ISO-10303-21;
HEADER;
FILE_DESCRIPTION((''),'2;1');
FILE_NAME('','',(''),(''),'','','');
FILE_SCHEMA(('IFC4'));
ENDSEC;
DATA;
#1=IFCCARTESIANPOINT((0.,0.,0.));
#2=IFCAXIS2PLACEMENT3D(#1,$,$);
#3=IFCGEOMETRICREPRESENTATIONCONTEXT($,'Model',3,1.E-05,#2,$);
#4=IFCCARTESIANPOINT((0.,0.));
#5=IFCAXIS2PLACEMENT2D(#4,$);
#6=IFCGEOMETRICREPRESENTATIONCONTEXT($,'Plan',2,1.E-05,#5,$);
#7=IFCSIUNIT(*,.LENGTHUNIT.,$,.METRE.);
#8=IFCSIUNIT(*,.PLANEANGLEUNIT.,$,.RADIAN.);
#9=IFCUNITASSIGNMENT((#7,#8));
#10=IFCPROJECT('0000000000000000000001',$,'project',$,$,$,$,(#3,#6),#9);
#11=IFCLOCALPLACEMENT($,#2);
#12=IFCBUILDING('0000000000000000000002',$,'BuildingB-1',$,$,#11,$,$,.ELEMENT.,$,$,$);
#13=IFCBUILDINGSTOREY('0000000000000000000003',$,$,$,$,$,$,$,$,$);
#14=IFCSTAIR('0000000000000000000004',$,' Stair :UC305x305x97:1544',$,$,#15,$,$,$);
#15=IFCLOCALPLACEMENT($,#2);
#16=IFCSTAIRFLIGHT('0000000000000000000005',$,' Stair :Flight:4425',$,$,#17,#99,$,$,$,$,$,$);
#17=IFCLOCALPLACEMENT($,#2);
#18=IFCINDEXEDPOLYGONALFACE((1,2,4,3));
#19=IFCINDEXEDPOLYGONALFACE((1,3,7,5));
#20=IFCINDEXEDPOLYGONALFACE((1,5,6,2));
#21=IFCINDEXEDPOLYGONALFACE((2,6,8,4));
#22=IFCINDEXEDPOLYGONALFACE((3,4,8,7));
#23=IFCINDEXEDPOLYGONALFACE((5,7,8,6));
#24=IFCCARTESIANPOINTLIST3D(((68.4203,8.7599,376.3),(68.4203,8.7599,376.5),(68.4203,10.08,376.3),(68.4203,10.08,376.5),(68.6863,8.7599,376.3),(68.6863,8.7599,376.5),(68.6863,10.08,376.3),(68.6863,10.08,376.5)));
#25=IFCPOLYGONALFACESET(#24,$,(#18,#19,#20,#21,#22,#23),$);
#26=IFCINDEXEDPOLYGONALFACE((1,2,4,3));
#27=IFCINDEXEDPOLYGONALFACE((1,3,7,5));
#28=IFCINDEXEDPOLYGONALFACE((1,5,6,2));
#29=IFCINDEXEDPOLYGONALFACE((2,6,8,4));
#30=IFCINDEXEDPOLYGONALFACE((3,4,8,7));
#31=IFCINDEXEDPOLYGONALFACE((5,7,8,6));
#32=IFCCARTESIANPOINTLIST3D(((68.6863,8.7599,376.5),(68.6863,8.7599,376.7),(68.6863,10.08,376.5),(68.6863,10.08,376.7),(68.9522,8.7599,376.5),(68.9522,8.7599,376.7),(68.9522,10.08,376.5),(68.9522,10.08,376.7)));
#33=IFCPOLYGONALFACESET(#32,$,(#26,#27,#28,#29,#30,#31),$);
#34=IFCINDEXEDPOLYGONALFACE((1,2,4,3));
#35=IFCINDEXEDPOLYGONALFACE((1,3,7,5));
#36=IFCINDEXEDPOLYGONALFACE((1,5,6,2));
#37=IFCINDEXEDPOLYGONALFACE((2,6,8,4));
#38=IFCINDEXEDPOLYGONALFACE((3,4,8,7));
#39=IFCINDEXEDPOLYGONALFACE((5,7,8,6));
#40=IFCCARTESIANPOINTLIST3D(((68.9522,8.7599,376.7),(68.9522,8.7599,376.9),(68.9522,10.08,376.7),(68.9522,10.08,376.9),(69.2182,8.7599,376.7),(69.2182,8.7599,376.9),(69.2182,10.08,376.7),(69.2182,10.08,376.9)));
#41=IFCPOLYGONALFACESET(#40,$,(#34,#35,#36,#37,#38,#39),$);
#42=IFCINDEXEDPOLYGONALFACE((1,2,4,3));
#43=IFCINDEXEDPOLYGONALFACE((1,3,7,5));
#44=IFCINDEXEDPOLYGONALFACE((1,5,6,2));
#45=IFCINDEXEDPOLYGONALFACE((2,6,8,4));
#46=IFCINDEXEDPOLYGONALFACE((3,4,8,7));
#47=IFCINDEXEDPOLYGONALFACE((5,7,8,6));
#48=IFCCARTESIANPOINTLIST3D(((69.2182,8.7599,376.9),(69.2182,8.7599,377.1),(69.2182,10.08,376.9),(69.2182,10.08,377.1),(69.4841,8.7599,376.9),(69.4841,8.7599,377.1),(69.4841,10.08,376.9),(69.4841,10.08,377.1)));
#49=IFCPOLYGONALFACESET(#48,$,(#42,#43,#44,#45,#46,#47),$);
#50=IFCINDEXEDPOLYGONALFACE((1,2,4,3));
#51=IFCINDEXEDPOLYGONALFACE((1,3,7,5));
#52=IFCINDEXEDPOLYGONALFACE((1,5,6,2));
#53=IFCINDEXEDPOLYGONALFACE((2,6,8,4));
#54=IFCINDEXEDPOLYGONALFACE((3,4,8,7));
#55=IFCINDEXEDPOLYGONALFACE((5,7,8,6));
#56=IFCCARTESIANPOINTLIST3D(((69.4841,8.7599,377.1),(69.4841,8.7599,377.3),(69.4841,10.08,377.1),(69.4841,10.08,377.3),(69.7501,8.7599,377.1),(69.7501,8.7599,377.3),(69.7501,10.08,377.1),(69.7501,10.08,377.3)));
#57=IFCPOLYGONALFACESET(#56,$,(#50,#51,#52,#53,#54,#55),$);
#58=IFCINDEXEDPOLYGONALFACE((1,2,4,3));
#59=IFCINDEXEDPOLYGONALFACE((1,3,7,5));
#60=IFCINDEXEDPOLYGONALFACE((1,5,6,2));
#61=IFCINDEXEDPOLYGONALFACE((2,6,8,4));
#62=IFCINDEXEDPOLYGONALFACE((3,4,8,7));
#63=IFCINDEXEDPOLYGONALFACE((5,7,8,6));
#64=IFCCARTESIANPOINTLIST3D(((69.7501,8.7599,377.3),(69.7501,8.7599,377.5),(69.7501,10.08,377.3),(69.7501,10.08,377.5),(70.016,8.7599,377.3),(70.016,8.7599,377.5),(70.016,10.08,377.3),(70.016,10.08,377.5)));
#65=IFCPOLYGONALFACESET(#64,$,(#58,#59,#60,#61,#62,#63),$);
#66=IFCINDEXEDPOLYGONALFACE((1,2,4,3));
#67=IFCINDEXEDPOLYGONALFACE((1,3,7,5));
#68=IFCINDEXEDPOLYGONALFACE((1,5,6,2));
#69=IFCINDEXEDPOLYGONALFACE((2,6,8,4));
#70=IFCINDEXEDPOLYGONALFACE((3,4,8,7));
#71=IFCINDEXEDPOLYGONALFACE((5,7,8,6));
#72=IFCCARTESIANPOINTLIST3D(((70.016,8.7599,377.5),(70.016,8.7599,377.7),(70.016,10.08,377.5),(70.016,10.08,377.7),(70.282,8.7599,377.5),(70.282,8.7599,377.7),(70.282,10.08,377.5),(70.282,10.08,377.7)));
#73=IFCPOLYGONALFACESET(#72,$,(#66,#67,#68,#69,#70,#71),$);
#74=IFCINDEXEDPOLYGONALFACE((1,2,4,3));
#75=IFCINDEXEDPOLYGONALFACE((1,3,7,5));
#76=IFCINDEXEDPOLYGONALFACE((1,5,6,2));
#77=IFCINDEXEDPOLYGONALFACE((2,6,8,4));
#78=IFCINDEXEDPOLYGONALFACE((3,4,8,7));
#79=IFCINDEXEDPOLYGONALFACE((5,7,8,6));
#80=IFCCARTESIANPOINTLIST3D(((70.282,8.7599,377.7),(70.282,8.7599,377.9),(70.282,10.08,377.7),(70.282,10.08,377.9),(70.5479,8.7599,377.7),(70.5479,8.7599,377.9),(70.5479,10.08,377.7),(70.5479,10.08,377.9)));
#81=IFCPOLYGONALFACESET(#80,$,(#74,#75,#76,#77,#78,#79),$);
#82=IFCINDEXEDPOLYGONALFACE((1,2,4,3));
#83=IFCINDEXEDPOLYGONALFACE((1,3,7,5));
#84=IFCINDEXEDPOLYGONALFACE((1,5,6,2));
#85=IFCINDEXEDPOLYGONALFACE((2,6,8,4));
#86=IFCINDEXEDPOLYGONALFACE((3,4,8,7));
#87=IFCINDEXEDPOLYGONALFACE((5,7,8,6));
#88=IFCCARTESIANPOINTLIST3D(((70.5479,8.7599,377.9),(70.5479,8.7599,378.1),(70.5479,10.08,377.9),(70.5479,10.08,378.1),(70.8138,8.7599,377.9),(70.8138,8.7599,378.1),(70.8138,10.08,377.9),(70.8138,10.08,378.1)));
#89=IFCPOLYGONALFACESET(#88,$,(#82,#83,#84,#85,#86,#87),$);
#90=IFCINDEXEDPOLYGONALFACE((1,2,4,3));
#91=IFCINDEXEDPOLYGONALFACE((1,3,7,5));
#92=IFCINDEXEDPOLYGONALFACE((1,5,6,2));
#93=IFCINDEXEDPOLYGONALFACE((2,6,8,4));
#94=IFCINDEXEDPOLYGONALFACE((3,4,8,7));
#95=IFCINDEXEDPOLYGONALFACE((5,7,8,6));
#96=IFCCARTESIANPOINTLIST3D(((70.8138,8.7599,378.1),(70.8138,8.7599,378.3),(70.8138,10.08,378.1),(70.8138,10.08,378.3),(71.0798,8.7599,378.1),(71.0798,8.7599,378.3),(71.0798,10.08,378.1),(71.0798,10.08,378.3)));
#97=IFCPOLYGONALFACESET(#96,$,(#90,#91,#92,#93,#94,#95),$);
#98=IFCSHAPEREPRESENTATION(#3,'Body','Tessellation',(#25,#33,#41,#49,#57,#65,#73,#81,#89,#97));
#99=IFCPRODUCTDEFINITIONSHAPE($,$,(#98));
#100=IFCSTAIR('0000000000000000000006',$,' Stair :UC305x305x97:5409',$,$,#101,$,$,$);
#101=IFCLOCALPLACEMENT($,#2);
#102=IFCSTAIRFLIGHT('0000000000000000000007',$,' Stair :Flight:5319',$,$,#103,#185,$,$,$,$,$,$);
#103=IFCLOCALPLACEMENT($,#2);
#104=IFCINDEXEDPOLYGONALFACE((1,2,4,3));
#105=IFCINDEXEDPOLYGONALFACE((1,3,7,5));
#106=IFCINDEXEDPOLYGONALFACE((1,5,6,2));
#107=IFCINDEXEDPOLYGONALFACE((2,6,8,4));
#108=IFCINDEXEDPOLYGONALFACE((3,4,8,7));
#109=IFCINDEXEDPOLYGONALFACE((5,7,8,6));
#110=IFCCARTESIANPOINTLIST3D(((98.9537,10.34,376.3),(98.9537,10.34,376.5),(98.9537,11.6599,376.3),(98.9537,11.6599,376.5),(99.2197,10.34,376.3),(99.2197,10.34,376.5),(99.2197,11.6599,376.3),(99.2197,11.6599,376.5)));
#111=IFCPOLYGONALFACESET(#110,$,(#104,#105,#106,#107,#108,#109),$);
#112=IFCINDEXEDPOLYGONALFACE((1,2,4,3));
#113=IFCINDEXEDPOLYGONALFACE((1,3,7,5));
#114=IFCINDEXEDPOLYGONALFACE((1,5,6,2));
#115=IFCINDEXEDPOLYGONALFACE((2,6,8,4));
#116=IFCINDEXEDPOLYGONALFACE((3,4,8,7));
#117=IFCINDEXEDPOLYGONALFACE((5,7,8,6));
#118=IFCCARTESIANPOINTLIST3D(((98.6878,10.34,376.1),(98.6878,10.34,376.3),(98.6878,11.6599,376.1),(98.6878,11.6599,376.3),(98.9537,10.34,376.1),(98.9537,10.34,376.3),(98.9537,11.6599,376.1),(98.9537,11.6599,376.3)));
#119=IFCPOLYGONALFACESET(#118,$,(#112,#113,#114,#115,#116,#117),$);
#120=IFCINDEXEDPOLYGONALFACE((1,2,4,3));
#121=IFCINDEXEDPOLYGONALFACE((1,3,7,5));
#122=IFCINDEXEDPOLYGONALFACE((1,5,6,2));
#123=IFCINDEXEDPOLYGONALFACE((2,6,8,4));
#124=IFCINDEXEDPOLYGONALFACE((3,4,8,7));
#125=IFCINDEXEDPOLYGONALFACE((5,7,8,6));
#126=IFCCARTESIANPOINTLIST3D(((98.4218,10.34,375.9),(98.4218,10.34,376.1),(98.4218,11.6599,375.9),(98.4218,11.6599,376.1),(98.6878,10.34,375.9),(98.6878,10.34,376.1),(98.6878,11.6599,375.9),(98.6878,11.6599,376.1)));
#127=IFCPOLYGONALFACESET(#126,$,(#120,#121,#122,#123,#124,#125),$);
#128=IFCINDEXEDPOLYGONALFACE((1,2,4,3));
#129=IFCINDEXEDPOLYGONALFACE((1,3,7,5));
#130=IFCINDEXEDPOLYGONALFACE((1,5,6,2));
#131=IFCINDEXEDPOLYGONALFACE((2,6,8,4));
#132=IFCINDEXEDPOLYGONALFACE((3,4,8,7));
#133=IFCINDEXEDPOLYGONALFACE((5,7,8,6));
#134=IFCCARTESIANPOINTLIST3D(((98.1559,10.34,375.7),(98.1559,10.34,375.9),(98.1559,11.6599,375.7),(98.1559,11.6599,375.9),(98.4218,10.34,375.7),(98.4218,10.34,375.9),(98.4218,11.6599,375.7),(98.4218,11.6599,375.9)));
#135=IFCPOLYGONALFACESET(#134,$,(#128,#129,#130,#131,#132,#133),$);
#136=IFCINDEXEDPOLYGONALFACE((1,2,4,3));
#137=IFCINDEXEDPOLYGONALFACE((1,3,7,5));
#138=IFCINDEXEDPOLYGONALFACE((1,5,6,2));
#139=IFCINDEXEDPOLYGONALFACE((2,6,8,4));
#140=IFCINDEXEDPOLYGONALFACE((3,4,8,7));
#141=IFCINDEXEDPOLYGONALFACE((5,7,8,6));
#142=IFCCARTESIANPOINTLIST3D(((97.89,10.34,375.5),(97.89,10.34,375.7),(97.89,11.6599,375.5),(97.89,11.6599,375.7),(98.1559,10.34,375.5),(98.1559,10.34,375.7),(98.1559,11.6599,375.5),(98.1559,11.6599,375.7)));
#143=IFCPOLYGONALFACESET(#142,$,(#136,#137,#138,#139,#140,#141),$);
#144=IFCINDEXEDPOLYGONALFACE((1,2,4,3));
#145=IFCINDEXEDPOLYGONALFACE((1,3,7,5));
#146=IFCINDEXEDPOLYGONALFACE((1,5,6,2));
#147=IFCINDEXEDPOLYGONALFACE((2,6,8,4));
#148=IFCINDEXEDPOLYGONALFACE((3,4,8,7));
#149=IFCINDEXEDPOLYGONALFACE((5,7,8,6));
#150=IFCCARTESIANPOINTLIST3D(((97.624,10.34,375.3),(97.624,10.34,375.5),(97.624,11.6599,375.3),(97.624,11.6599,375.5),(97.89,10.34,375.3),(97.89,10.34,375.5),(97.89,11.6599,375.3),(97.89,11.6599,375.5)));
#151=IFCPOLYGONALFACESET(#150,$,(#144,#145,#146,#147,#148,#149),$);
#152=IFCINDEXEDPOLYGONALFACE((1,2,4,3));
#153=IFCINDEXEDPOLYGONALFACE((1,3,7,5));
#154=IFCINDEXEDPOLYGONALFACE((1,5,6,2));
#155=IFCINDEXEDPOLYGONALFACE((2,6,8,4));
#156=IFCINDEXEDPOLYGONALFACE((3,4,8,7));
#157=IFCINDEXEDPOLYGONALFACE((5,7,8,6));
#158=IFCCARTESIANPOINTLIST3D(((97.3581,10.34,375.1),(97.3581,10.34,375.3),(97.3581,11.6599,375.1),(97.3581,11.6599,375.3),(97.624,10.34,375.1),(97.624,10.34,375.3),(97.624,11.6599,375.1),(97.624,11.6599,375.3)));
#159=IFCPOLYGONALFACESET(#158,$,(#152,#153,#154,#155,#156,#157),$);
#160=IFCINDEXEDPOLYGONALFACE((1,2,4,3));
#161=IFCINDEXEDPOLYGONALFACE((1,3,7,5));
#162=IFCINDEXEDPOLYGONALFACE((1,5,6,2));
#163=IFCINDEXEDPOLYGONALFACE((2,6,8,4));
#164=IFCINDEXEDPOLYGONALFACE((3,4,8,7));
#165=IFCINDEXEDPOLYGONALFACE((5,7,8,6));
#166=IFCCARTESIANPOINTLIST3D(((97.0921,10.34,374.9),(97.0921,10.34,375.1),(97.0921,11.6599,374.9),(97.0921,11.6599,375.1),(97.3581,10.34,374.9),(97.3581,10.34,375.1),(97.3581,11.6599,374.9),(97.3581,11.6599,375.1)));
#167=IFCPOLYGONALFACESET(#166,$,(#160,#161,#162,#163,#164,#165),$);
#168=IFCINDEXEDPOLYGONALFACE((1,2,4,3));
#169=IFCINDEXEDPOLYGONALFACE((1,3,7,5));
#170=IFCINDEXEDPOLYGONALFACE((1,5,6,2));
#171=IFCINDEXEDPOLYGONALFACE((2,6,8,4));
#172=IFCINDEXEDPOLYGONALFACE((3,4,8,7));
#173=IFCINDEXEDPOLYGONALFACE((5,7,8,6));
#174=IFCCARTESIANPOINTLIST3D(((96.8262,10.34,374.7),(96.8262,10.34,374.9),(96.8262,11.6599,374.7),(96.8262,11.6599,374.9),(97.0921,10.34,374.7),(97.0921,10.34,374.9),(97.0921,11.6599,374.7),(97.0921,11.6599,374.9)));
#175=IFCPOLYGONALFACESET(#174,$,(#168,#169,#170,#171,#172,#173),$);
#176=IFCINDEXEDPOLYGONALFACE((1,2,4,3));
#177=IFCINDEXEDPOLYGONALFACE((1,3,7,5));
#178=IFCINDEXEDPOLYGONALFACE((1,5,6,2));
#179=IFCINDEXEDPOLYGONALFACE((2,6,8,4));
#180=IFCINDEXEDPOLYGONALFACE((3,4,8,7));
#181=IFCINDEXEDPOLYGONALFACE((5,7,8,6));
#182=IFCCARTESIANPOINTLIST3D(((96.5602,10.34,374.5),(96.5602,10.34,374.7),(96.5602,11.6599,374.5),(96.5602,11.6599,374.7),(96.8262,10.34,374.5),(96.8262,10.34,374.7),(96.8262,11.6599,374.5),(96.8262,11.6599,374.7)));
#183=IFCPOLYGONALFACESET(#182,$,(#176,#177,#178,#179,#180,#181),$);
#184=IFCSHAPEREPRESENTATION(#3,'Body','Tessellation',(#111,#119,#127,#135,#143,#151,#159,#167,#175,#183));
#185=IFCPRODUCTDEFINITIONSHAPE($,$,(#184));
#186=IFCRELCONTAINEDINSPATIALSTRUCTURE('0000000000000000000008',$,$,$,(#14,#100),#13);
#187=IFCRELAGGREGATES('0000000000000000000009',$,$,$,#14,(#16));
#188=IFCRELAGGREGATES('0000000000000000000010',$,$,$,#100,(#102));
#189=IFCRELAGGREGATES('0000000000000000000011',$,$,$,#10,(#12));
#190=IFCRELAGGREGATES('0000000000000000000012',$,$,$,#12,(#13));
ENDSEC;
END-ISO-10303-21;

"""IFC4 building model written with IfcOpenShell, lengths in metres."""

from ifc_helpers import new_model, si_unit, frame, origin, origin_2d, place, context, project, spatial, polyline, outline, extrude, element, aggregate, save


model = new_model("IFC4")

# Units and contexts
model_context = context("Model", 3, precision=1e-05, world=origin())
plan_context = context("Plan", 2, precision=1e-05, world=origin_2d())
ifc_project = project(units=[si_unit("LENGTHUNIT", "METRE"), si_unit("PLANEANGLEUNIT", "RADIAN")], contexts=[model_context, plan_context])

# Building, storey
building_placement = place(None, origin())
building = spatial("IfcBuilding", under=ifc_project, at=building_placement, Name="BuildingB-1", CompositionType="ELEMENT")
storey = spatial("IfcBuildingStorey", under=building)

# Stairs, stair flights
stair_1 = element("IfcStair", 1, inside=storey, Name=" Stair :UC305x305x97:1544")
stair_flight_1 = element("IfcStairFlight", 2, Name=" Stair :Flight:4425", context=model_context, shape_type="SweptSolid", body=[
    extrude(outline(polyline([(68.6863, 8.7599, 376.5), (68.6863, 10.08, 376.5), (68.4203, 10.08, 376.5), (68.4203, 8.7599, 376.5), (68.6863, 8.7599, 376.5)])), origin(), (0.0, 0.0, -1.0), 0.2),
    extrude(outline(polyline([(68.9522, 8.7599, 376.5), (68.9522, 10.08, 376.5), (68.6863, 10.08, 376.5), (68.6863, 8.7599, 376.5), (68.9522, 8.7599, 376.5)])), frame((0.0, 0.0, 0.2)), (0.0, 0.0, -1.0), 0.2),
    extrude(outline(polyline([(69.2182, 8.7599, 376.5), (69.2182, 10.08, 376.5), (68.9522, 10.08, 376.5), (68.9522, 8.7599, 376.5), (69.2182, 8.7599, 376.5)])), frame((0.0, 0.0, 0.4)), (0.0, 0.0, -1.0), 0.2),
    extrude(outline(polyline([(69.4841, 8.7599, 376.5), (69.4841, 10.08, 376.5), (69.2182, 10.08, 376.5), (69.2182, 8.7599, 376.5), (69.4841, 8.7599, 376.5)])), frame((0.0, 0.0, 0.6)), (0.0, 0.0, -1.0), 0.2),
    extrude(outline(polyline([(69.7501, 8.7599, 376.5), (69.7501, 10.08, 376.5), (69.4841, 10.08, 376.5), (69.4841, 8.7599, 376.5), (69.7501, 8.7599, 376.5)])), frame((0.0, 0.0, 0.8)), (0.0, 0.0, -1.0), 0.2),
    extrude(outline(polyline([(70.016, 8.7599, 376.5), (70.016, 10.08, 376.5), (69.7501, 10.08, 376.5), (69.7501, 8.7599, 376.5), (70.016, 8.7599, 376.5)])), frame((0.0, 0.0, 1.0)), (0.0, 0.0, -1.0), 0.2),
    extrude(outline(polyline([(70.282, 8.7599, 376.5), (70.282, 10.08, 376.5), (70.016, 10.08, 376.5), (70.016, 8.7599, 376.5), (70.282, 8.7599, 376.5)])), frame((0.0, 0.0, 1.2)), (0.0, 0.0, -1.0), 0.2),
    extrude(outline(polyline([(70.5479, 8.7599, 376.5), (70.5479, 10.08, 376.5), (70.282, 10.08, 376.5), (70.282, 8.7599, 376.5), (70.5479, 8.7599, 376.5)])), frame((0.0, 0.0, 1.4)), (0.0, 0.0, -1.0), 0.2),
    extrude(outline(polyline([(70.8138, 8.7599, 376.5), (70.8138, 10.08, 376.5), (70.5479, 10.08, 376.5), (70.5479, 8.7599, 376.5), (70.8138, 8.7599, 376.5)])), frame((0.0, 0.0, 1.6)), (0.0, 0.0, -1.0), 0.2),
    extrude(outline(polyline([(71.0798, 8.7599, 376.5), (71.0798, 10.08, 376.5), (70.8138, 10.08, 376.5), (70.8138, 8.7599, 376.5), (71.0798, 8.7599, 376.5)])), frame((0.0, 0.0, 1.8)), (0.0, 0.0, -1.0), 0.2),
])
aggregate(stair_1, [stair_flight_1])
stair_2 = element("IfcStair", 3, inside=storey, Name=" Stair :UC305x305x97:5409")
stair_flight_2 = element("IfcStairFlight", 4, Name=" Stair :Flight:5319", context=model_context, shape_type="SweptSolid", body=[
    extrude(outline(polyline([(98.9537, 11.6599, 376.5), (98.9537, 10.34, 376.5), (99.2197, 10.34, 376.5), (99.2197, 11.6599, 376.5), (98.9537, 11.6599, 376.5)])), origin(), (0.0, 0.0, -1.0), 0.2),
    extrude(outline(polyline([(98.6878, 11.6599, 376.5), (98.6878, 10.34, 376.5), (98.9537, 10.34, 376.5), (98.9537, 11.6599, 376.5), (98.6878, 11.6599, 376.5)])), frame((0.0, 0.0, -0.2)), (0.0, 0.0, -1.0), 0.2),
    extrude(outline(polyline([(98.4218, 11.6599, 376.5), (98.4218, 10.34, 376.5), (98.6878, 10.34, 376.5), (98.6878, 11.6599, 376.5), (98.4218, 11.6599, 376.5)])), frame((0.0, 0.0, -0.4)), (0.0, 0.0, -1.0), 0.2),
    extrude(outline(polyline([(98.1559, 11.6599, 376.5), (98.1559, 10.34, 376.5), (98.4218, 10.34, 376.5), (98.4218, 11.6599, 376.5), (98.1559, 11.6599, 376.5)])), frame((0.0, 0.0, -0.6)), (0.0, 0.0, -1.0), 0.2),
    extrude(outline(polyline([(97.89, 11.6599, 376.5), (97.89, 10.34, 376.5), (98.1559, 10.34, 376.5), (98.1559, 11.6599, 376.5), (97.89, 11.6599, 376.5)])), frame((0.0, 0.0, -0.8)), (0.0, 0.0, -1.0), 0.2),
    extrude(outline(polyline([(97.624, 11.6599, 376.5), (97.624, 10.34, 376.5), (97.89, 10.34, 376.5), (97.89, 11.6599, 376.5), (97.624, 11.6599, 376.5)])), frame((0.0, 0.0, -1.0)), (0.0, 0.0, -1.0), 0.2),
    extrude(outline(polyline([(97.3581, 11.6599, 376.5), (97.3581, 10.34, 376.5), (97.624, 10.34, 376.5), (97.624, 11.6599, 376.5), (97.3581, 11.6599, 376.5)])), frame((0.0, 0.0, -1.2)), (0.0, 0.0, -1.0), 0.2),
    extrude(outline(polyline([(97.0921, 11.6599, 376.5), (97.0921, 10.34, 376.5), (97.3581, 10.34, 376.5), (97.3581, 11.6599, 376.5), (97.0921, 11.6599, 376.5)])), frame((0.0, 0.0, -1.4)), (0.0, 0.0, -1.0), 0.2),
    extrude(outline(polyline([(96.8262, 11.6599, 376.5), (96.8262, 10.34, 376.5), (97.0921, 10.34, 376.5), (97.0921, 11.6599, 376.5), (96.8262, 11.6599, 376.5)])), frame((0.0, 0.0, -1.6)), (0.0, 0.0, -1.0), 0.2),
    extrude(outline(polyline([(96.5602, 11.6599, 376.5), (96.5602, 10.34, 376.5), (96.8262, 10.34, 376.5), (96.8262, 11.6599, 376.5), (96.5602, 11.6599, 376.5)])), frame((0.0, 0.0, -1.8)), (0.0, 0.0, -1.0), 0.2),
])
aggregate(stair_2, [stair_flight_2])

save(model, "model.ifc")
